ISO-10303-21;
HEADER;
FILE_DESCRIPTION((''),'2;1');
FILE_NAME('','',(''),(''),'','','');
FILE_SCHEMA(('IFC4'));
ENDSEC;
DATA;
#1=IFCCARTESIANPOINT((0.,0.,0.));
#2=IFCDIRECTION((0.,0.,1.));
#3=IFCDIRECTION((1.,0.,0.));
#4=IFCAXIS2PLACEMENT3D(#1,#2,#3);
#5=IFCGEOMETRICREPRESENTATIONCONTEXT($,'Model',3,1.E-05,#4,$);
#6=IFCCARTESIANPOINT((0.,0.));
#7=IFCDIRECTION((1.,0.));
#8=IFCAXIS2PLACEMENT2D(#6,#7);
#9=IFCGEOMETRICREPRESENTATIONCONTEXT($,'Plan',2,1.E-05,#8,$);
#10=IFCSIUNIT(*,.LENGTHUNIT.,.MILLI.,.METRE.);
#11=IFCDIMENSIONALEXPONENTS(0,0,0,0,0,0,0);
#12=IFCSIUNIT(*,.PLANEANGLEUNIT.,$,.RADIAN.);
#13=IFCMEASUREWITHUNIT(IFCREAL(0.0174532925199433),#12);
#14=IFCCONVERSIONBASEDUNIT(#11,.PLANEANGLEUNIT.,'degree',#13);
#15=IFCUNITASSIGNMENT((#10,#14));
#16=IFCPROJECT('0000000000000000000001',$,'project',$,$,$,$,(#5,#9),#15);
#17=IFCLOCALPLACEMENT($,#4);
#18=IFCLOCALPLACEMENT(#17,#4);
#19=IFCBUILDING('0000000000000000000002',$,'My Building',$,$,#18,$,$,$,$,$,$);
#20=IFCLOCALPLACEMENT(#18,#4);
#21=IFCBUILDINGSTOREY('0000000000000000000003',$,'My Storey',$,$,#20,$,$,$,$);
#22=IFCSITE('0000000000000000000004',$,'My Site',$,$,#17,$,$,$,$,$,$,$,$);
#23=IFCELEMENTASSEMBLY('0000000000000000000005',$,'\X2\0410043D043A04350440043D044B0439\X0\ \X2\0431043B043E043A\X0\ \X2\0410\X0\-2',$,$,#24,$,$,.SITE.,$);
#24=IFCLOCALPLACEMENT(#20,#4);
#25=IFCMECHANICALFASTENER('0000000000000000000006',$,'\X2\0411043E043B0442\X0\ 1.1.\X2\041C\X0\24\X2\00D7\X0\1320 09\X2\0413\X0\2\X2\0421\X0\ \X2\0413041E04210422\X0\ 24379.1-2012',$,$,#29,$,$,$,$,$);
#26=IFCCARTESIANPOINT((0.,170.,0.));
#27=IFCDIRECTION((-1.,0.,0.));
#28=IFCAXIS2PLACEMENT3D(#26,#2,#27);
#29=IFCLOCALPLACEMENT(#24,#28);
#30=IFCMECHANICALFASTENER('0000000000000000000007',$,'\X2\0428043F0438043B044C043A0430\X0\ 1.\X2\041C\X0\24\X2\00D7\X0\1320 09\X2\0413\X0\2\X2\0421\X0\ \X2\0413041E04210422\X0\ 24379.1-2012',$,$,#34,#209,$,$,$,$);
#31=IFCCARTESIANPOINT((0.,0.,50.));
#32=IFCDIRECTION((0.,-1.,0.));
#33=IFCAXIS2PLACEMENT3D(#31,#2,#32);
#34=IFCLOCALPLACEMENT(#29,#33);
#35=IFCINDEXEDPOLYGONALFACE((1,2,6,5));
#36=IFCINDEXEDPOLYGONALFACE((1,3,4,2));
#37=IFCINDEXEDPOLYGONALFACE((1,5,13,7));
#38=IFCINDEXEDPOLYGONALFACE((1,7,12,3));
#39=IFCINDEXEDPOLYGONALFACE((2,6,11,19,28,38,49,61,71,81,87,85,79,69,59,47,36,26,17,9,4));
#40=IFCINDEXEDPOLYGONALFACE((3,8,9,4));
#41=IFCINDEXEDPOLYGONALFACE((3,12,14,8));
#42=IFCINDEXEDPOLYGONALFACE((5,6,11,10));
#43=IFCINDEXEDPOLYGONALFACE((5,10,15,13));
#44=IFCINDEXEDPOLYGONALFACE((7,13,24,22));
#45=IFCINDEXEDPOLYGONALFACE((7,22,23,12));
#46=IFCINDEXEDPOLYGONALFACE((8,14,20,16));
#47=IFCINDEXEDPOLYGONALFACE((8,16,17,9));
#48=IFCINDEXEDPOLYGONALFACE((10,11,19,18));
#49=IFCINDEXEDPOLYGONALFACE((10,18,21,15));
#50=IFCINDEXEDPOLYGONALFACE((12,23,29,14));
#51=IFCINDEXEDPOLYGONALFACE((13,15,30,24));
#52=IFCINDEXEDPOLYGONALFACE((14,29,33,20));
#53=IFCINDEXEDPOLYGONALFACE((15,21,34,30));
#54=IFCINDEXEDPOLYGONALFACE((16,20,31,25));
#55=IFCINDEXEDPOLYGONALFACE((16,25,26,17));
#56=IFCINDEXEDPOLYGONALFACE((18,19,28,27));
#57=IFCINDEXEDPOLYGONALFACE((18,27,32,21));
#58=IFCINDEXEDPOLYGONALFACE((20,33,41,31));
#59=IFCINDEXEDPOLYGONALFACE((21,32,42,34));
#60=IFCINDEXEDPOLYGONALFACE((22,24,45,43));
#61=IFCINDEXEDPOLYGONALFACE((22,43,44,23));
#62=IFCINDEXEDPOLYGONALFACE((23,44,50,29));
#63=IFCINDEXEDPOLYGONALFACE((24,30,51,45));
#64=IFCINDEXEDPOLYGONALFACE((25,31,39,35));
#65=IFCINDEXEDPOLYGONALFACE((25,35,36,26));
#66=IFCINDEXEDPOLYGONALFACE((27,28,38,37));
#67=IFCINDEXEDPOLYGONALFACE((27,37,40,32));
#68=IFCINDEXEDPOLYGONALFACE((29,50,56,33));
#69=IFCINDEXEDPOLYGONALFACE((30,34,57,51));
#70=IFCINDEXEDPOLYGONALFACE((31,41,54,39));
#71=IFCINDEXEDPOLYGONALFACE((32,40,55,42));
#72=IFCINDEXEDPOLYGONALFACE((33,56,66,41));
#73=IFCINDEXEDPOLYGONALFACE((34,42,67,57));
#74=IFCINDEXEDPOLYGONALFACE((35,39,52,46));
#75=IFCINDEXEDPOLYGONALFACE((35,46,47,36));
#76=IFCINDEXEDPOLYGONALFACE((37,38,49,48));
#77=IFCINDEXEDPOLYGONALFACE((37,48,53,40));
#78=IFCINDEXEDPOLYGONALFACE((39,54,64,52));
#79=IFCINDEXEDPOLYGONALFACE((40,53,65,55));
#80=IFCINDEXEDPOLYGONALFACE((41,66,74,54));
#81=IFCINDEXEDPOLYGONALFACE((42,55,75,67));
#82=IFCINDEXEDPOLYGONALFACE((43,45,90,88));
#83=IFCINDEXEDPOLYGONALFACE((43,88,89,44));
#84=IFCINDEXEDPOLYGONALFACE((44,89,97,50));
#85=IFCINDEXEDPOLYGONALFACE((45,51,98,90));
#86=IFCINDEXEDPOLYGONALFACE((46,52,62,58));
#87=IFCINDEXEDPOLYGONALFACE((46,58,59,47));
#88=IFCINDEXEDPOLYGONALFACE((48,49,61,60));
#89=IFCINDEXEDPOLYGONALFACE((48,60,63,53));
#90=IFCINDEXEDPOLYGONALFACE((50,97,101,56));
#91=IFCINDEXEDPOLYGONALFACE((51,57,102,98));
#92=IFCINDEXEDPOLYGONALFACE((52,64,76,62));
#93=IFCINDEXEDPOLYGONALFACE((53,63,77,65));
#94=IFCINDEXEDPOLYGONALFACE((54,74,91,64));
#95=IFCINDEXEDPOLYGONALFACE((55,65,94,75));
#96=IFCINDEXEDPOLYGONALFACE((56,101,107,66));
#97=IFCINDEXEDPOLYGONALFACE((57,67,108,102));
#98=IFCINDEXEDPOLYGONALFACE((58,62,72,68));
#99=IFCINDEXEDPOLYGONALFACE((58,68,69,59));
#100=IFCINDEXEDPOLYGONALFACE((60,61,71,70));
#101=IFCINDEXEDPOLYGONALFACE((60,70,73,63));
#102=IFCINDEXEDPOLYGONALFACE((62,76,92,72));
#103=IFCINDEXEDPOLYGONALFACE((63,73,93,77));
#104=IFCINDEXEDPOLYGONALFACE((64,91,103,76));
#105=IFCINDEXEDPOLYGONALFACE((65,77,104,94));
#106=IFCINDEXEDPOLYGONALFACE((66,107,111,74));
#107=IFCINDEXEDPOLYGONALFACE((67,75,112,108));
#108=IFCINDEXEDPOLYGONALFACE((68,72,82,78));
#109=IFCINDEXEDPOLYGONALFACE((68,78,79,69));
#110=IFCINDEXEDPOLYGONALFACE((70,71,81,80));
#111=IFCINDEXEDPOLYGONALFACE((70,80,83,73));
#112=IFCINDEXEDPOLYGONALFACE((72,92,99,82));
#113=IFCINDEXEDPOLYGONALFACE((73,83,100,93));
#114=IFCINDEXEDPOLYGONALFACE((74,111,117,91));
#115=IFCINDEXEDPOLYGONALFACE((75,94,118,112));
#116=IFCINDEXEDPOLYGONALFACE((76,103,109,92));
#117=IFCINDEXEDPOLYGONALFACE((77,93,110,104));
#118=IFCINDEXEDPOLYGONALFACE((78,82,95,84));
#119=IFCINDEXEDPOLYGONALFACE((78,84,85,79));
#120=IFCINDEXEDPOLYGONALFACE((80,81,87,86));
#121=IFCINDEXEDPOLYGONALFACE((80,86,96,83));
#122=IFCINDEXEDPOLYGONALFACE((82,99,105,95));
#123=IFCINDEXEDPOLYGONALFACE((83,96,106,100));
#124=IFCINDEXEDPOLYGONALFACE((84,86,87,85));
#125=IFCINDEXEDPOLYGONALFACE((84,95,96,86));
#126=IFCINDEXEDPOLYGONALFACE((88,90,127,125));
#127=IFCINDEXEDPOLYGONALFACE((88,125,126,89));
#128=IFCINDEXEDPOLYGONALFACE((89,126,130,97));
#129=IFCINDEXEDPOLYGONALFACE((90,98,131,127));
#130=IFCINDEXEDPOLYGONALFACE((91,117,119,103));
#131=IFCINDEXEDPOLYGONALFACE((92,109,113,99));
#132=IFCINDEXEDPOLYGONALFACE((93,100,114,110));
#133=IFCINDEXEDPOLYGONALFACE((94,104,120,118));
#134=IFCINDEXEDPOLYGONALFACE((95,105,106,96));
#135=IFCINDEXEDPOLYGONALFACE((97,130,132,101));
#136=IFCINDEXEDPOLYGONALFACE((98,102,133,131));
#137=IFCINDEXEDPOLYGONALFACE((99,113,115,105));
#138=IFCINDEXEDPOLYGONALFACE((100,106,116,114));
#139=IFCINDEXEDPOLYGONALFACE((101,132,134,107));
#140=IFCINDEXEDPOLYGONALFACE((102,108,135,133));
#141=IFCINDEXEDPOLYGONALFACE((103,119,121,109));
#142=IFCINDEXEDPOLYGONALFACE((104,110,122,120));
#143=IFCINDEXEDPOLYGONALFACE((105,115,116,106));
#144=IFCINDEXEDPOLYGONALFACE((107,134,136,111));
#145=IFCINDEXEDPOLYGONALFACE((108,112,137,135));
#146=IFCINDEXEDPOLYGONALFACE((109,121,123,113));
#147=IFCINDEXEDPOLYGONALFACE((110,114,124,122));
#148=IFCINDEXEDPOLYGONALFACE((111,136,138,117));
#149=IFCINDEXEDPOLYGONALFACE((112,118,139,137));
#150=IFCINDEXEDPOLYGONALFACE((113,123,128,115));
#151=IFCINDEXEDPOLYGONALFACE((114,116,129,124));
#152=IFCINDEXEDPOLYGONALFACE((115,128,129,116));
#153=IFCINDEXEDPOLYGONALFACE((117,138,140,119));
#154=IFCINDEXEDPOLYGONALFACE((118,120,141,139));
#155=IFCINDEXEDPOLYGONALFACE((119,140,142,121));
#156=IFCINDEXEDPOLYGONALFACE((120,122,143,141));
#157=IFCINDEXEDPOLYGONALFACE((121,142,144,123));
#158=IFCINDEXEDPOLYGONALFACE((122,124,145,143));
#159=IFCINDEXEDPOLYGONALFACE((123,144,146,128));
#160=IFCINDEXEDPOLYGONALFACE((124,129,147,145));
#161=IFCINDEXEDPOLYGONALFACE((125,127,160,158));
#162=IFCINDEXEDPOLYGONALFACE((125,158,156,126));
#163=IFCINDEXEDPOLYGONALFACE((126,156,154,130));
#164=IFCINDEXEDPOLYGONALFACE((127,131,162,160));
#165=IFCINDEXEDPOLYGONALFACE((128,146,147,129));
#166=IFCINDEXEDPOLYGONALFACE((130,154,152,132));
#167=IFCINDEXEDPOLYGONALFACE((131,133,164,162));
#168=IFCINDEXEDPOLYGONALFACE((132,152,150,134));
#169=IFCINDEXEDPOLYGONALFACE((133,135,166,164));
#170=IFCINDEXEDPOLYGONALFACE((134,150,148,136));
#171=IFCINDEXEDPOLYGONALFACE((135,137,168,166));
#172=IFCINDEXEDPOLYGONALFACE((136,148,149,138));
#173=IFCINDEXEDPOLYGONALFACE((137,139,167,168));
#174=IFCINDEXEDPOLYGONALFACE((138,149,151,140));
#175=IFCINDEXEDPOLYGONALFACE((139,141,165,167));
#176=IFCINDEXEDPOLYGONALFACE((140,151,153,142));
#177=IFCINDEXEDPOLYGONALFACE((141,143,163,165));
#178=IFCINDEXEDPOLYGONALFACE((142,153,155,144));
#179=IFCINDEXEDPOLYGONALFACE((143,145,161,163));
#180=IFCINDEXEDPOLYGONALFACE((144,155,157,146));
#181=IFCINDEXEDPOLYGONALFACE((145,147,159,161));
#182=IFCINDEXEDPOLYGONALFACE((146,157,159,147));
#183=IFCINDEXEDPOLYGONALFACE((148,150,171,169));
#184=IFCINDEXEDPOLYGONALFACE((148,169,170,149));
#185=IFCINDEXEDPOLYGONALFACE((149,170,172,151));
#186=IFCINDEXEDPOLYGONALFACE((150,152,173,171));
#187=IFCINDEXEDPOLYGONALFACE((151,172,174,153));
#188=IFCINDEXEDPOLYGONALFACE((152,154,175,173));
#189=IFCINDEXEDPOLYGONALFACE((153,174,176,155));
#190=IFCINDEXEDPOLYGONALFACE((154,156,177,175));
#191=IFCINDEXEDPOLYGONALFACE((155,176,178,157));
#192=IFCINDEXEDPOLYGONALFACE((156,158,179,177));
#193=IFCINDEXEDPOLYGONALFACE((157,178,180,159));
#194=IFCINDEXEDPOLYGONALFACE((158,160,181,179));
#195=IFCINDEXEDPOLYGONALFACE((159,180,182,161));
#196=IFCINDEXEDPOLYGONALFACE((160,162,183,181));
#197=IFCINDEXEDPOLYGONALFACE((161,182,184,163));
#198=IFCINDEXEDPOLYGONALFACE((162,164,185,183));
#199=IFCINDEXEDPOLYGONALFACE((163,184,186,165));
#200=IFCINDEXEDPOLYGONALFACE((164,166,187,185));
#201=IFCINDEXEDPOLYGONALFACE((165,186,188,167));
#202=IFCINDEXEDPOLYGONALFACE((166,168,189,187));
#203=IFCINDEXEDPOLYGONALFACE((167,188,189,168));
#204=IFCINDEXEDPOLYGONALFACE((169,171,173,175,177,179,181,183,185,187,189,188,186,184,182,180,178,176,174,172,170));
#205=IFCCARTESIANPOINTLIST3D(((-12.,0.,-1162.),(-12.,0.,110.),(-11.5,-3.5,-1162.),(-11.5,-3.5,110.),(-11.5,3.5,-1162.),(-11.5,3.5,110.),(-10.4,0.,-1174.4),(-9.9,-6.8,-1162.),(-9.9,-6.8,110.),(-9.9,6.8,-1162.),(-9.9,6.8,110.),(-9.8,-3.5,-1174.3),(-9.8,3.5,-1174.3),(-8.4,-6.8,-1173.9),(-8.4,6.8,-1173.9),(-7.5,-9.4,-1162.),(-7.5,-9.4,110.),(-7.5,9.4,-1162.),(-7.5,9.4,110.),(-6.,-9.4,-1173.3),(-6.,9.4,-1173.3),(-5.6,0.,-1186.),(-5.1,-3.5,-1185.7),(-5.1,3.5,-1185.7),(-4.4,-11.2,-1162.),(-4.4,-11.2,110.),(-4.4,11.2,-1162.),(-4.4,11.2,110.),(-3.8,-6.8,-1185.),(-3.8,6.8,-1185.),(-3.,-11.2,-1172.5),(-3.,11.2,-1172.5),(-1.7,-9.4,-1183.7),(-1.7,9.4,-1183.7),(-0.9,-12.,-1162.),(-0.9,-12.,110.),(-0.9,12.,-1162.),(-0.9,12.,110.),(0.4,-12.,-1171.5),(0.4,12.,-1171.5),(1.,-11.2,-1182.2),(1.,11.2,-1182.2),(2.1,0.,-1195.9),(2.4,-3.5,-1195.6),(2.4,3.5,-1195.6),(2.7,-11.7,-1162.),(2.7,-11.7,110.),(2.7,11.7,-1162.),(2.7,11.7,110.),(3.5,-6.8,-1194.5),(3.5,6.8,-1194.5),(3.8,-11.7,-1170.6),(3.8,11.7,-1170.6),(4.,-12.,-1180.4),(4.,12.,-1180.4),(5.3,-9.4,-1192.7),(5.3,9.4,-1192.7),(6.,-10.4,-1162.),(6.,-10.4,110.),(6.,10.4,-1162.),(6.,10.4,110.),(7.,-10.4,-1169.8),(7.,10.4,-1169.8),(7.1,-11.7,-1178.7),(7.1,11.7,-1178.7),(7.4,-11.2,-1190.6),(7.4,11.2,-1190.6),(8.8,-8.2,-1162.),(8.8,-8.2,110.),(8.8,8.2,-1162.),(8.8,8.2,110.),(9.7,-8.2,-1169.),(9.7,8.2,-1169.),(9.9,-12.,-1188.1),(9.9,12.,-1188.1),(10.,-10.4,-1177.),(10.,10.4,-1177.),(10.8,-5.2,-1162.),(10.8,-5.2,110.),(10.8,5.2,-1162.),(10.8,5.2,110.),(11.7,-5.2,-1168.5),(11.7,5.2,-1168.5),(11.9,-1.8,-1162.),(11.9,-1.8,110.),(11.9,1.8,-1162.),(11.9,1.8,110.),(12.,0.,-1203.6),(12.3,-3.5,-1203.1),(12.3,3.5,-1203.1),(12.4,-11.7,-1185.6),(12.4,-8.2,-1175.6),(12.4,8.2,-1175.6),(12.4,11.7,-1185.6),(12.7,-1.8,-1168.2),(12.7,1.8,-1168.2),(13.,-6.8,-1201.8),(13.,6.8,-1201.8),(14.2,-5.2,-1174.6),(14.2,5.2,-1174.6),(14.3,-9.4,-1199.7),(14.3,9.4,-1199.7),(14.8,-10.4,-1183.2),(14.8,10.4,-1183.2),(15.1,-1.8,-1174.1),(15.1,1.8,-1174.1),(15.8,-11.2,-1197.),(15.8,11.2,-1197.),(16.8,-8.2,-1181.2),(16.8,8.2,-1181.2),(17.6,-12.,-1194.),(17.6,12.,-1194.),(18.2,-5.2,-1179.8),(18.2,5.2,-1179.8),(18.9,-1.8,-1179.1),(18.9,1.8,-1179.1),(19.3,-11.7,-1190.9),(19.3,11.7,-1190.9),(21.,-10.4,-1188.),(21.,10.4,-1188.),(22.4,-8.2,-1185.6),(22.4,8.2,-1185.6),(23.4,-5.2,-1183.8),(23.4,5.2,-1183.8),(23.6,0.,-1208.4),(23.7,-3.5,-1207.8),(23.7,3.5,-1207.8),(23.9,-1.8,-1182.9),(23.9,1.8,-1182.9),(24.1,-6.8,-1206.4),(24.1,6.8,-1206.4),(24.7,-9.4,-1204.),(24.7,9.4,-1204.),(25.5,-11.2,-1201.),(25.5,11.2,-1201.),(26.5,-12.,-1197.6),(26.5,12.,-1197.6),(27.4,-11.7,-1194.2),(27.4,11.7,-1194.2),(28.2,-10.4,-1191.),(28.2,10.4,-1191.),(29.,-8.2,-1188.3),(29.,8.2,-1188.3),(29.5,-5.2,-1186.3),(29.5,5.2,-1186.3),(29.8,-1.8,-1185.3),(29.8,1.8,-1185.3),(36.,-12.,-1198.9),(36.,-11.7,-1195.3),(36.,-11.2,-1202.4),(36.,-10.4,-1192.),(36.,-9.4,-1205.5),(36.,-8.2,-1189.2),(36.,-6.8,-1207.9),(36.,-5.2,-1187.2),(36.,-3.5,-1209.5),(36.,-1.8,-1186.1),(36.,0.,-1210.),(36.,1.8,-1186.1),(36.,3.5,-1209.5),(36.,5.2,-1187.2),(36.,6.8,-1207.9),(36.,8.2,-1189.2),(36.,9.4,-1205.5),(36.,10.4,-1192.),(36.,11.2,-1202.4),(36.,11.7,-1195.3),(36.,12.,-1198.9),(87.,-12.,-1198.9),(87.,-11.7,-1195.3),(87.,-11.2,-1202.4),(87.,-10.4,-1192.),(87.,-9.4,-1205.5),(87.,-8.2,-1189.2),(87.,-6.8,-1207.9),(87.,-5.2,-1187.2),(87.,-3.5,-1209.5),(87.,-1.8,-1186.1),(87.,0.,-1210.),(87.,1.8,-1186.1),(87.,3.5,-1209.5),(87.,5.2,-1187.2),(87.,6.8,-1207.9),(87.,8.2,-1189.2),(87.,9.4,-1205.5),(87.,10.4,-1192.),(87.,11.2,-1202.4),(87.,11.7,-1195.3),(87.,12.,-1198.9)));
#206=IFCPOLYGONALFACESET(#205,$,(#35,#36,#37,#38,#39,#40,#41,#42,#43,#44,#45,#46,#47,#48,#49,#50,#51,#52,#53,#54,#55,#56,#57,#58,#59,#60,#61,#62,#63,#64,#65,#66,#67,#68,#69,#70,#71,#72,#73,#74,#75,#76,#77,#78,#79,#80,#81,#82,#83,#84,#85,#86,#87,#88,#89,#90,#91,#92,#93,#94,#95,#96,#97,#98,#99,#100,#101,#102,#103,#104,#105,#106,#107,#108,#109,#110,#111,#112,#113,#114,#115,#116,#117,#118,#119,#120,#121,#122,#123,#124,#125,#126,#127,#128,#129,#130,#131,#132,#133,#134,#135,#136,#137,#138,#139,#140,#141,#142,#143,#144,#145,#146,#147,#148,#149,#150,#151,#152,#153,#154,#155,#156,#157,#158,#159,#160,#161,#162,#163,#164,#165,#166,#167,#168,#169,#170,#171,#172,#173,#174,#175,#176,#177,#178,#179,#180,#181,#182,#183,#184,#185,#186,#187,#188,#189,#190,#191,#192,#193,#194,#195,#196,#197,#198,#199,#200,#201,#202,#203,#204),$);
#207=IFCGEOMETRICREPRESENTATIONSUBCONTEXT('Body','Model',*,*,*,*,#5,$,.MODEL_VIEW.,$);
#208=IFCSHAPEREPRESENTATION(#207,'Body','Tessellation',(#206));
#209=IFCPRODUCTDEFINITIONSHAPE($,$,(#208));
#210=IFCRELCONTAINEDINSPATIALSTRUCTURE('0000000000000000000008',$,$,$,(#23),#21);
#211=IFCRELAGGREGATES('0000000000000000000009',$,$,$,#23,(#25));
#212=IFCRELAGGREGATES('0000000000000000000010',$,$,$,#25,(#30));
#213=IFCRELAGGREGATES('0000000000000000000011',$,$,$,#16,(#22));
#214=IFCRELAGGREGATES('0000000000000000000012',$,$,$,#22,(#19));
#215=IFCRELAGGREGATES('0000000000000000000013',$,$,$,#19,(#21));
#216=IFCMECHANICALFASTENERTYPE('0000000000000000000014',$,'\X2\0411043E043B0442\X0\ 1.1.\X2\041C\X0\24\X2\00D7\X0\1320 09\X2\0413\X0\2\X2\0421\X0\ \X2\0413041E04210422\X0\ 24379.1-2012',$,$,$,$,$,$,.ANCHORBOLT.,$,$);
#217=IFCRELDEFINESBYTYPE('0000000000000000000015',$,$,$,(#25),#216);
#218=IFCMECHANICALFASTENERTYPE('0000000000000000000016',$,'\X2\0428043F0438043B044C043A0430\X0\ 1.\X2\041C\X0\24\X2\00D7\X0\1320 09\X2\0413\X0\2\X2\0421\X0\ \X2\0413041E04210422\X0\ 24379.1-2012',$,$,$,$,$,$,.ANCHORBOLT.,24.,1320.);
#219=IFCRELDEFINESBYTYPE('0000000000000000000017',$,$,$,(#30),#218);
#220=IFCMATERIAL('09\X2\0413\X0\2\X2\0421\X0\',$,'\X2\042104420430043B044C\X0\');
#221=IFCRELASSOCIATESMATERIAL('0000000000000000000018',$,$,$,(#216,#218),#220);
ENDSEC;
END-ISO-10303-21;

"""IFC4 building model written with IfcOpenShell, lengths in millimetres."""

from ifc_helpers import new_model, entity, si_unit, converted_unit, frame, origin_with_axes, origin_2d_with_axis, place, context, subcontext, project, spatial, source, transform, mapped, material, type_object, type_shapes, element, aggregate, save


model = new_model("IFC4")

# Units and contexts
model_context = context("Model", 3, precision=1e-05, world=origin_with_axes())
plan_context = context("Plan", 2, precision=1e-05, world=origin_2d_with_axis())
body_context = subcontext(model_context, "Body", "Model", "MODEL_VIEW")
ifc_project = project(units=[si_unit("LENGTHUNIT", "METRE", prefix="MILLI"), converted_unit("PLANEANGLEUNIT", "degree", entity("IfcReal", 0.0174532925199433), si_unit("PLANEANGLEUNIT", "RADIAN"), dimensions=[0, 0, 0, 0, 0, 0, 0])], contexts=[model_context, plan_context])

# Site, building, storey
site_placement = place(None, origin_with_axes())
site = spatial("IfcSite", under=ifc_project, at=site_placement, Name="My Site")
building_placement = place(site_placement, origin_with_axes())
building = spatial("IfcBuilding", under=site, at=building_placement, Name="My Building")
storey_placement = place(building_placement, origin_with_axes())
storey = spatial("IfcBuildingStorey", under=building, at=storey_placement, Name="My Storey")

# Element assembly
placement_1 = place(storey_placement, origin_with_axes())
assembly_1 = element("IfcElementAssembly", 1, at=placement_1, inside=storey, Name="Анкерный блок А-2", AssemblyPlace="SITE")

# Shared definitions
ifc_material_1 = material(Name="09Г2С", Category="Сталь")
mechanical_fastener_type_1 = type_object("IfcMechanicalFastenerType", Name="Болт 1.1.М24×1320 09Г2С ГОСТ 24379.1-2012", PredefinedType="ANCHORBOLT", material=ifc_material_1)
mechanical_fastener_type_2 = type_object("IfcMechanicalFastenerType", Name="Шпилька 1.М24×1320 09Г2С ГОСТ 24379.1-2012", NominalDiameter=24.0, NominalLength=1320.0, PredefinedType="ANCHORBOLT", material=ifc_material_1)
shared_shape_1 = source(frame((0.0, 0.0, 110.0), z_axis=(0.0, 0.0, 1.0), x_axis=(1.0, 0.0, 0.0)), body_context, "Body", "AdvancedSweptSolid", [
    entity("IfcSweptDiskSolid", entity("IfcIndexedPolyCurve", entity("IfcCartesianPointList3D", [[0.0, 0.0, 0.0], [0.0, 0.0, -1272.0], [10.5, 0.0, -1297.5], [36.0, 0.0, -1308.0], [87.0, 0.0, -1308.0]]), [entity("IfcLineIndex", [1, 2]), entity("IfcArcIndex", [2, 3, 4]), entity("IfcLineIndex", [4, 5])]), 12.0),
])
type_shapes(mechanical_fastener_type_2, [shared_shape_1])

# Mechanical fasteners
mechanical_fastener_1_placement = place(placement_1, frame((0.0, 170.0, 0.0), z_axis=(0.0, 0.0, 1.0), x_axis=(-1.0, 0.0, 0.0)))
mechanical_fastener_1 = element("IfcMechanicalFastener", 2, at=mechanical_fastener_1_placement, type_object=mechanical_fastener_type_1, Name="Болт 1.1.М24×1320 09Г2С ГОСТ 24379.1-2012")
aggregate(assembly_1, [mechanical_fastener_1])
mechanical_fastener_2_placement = place(mechanical_fastener_1_placement, frame((0.0, 0.0, 50.0), z_axis=(0.0, 0.0, 1.0), x_axis=(0.0, -1.0, 0.0)))
mechanical_fastener_2 = element("IfcMechanicalFastener", 3, at=mechanical_fastener_2_placement, type_object=mechanical_fastener_type_2, Name="Шпилька 1.М24×1320 09Г2С ГОСТ 24379.1-2012", context=body_context, shape_type="MappedRepresentation", body=[
    mapped(shared_shape_1, transform((0.0, 0.0, 0.0), x_axis=(1.0, 0.0, 0.0), y_axis=(0.0, 1.0, 0.0), z_axis=(0.0, 0.0, 1.0), scale=1.0)),
])

aggregate(mechanical_fastener_1, [mechanical_fastener_2])

save(model, "model.ifc")
